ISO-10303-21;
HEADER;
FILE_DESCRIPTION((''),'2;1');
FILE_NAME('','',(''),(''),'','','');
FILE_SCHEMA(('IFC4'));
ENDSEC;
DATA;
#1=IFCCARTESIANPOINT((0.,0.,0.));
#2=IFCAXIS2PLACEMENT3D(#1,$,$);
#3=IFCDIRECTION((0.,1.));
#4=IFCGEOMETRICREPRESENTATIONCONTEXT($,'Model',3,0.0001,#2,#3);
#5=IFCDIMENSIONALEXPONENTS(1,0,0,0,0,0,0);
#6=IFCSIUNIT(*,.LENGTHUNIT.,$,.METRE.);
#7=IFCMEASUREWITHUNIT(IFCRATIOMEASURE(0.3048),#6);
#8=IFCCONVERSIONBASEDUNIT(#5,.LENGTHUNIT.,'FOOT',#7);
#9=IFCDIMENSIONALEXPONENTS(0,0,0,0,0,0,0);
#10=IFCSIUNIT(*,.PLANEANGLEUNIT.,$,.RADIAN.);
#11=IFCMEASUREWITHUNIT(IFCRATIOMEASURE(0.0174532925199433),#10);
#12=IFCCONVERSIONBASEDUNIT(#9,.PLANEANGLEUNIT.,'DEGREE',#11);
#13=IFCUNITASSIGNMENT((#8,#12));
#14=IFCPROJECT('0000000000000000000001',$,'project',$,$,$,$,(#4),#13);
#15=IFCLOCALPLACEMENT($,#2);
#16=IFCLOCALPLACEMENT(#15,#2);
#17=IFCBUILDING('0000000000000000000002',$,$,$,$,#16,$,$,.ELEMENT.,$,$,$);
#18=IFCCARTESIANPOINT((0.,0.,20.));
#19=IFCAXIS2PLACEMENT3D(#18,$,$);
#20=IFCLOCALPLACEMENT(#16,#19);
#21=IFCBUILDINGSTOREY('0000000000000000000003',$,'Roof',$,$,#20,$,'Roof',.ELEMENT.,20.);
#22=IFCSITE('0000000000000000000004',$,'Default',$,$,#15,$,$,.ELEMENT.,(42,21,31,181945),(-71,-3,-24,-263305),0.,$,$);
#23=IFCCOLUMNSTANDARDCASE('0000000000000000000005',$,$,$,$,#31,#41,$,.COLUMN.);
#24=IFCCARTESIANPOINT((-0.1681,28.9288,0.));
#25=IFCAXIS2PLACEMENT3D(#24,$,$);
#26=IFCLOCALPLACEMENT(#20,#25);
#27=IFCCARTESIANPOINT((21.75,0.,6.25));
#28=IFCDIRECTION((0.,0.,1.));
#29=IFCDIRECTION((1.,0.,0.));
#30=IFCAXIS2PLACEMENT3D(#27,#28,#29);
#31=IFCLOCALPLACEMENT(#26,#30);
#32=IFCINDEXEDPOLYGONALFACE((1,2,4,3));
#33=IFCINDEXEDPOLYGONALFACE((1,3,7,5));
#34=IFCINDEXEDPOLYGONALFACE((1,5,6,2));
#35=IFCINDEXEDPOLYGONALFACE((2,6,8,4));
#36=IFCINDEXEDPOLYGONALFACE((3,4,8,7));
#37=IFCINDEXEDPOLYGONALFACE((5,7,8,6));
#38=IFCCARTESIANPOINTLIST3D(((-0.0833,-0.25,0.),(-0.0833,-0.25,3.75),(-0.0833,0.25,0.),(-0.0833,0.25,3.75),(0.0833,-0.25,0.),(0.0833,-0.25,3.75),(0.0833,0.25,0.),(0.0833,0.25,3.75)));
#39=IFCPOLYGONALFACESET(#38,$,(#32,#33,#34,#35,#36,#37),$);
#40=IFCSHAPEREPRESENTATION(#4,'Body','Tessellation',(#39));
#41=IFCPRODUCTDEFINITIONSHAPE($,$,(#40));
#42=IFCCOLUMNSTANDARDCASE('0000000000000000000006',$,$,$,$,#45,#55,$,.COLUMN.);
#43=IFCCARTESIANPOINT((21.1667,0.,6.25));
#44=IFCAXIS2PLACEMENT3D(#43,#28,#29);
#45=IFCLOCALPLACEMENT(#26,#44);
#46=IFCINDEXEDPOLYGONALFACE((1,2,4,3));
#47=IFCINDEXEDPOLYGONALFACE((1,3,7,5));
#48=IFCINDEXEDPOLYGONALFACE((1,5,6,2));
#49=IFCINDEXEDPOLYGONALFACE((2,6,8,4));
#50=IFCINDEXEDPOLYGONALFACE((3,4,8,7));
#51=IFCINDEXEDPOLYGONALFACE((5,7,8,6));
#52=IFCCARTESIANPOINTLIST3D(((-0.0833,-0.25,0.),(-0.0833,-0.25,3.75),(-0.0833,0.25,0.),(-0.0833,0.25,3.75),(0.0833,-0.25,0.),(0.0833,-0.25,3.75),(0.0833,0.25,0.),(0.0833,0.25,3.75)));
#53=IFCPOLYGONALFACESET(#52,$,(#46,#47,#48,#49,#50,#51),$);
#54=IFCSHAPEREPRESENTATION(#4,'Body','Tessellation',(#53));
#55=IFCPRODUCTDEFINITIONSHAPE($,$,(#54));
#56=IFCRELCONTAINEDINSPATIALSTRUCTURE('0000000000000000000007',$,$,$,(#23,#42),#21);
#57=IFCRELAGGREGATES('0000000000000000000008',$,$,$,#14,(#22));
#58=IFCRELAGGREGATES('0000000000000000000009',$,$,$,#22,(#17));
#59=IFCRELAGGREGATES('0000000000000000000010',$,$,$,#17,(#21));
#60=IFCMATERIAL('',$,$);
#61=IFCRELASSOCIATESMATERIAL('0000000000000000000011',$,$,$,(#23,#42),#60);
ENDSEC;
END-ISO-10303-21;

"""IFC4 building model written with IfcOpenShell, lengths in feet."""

from ifc_helpers import new_model, entity, si_unit, converted_unit, direction, frame, origin, place, context, project, spatial, rectangle, extrude, material, element, save


model = new_model("IFC4")

# Units and contexts
model_context = context("Model", 3, precision=0.0001, world=origin(), true_north=direction((0.0, 1.0)))
ifc_project = project(units=[converted_unit("LENGTHUNIT", "FOOT", entity("IfcRatioMeasure", 0.3048), si_unit("LENGTHUNIT", "METRE"), dimensions=[1, 0, 0, 0, 0, 0, 0]), converted_unit("PLANEANGLEUNIT", "DEGREE", entity("IfcRatioMeasure", 0.0174532925199433), si_unit("PLANEANGLEUNIT", "RADIAN"), dimensions=[0, 0, 0, 0, 0, 0, 0])], contexts=[model_context])

# Site, building, storey
site_placement = place(None, origin())
site = spatial("IfcSite", under=ifc_project, at=site_placement, Name="Default", CompositionType="ELEMENT", RefLatitude=(42, 21, 31, 181945), RefLongitude=(-71, -3, -24, -263305), RefElevation=0.0)
building_placement = place(site_placement, origin())
building = spatial("IfcBuilding", under=site, at=building_placement, CompositionType="ELEMENT")
storey_placement = place(building_placement, frame((0.0, 0.0, 20.0)))
storey = spatial("IfcBuildingStorey", under=building, at=storey_placement, Name="Roof", LongName="Roof", CompositionType="ELEMENT", Elevation=20.0)

# Columns
ifc_material = material(Name="")
placement = place(storey_placement, frame((-0.1681, 28.9288, 0.0)))
for number, where, z_axis, x_axis in (
    (1, (21.75, 0.0, 6.25), (0.0, 0.0, 1.0), (1.0, 0.0, 0.0)),
    (2, (21.1667, 0.0, 6.25), (0.0, 0.0, 1.0), (1.0, 0.0, 0.0)),
):
    element("IfcColumnStandardCase", number, at=place(placement, frame(where, z_axis=z_axis, x_axis=x_axis)), inside=storey, material=ifc_material, PredefinedType="COLUMN", context=model_context, shape_type="SweptSolid", body=[
        extrude(rectangle(XDim=0.1667, YDim=0.5), origin(), (0.0, 0.0, 1.0), 3.75),
    ])

save(model, "model.ifc")
